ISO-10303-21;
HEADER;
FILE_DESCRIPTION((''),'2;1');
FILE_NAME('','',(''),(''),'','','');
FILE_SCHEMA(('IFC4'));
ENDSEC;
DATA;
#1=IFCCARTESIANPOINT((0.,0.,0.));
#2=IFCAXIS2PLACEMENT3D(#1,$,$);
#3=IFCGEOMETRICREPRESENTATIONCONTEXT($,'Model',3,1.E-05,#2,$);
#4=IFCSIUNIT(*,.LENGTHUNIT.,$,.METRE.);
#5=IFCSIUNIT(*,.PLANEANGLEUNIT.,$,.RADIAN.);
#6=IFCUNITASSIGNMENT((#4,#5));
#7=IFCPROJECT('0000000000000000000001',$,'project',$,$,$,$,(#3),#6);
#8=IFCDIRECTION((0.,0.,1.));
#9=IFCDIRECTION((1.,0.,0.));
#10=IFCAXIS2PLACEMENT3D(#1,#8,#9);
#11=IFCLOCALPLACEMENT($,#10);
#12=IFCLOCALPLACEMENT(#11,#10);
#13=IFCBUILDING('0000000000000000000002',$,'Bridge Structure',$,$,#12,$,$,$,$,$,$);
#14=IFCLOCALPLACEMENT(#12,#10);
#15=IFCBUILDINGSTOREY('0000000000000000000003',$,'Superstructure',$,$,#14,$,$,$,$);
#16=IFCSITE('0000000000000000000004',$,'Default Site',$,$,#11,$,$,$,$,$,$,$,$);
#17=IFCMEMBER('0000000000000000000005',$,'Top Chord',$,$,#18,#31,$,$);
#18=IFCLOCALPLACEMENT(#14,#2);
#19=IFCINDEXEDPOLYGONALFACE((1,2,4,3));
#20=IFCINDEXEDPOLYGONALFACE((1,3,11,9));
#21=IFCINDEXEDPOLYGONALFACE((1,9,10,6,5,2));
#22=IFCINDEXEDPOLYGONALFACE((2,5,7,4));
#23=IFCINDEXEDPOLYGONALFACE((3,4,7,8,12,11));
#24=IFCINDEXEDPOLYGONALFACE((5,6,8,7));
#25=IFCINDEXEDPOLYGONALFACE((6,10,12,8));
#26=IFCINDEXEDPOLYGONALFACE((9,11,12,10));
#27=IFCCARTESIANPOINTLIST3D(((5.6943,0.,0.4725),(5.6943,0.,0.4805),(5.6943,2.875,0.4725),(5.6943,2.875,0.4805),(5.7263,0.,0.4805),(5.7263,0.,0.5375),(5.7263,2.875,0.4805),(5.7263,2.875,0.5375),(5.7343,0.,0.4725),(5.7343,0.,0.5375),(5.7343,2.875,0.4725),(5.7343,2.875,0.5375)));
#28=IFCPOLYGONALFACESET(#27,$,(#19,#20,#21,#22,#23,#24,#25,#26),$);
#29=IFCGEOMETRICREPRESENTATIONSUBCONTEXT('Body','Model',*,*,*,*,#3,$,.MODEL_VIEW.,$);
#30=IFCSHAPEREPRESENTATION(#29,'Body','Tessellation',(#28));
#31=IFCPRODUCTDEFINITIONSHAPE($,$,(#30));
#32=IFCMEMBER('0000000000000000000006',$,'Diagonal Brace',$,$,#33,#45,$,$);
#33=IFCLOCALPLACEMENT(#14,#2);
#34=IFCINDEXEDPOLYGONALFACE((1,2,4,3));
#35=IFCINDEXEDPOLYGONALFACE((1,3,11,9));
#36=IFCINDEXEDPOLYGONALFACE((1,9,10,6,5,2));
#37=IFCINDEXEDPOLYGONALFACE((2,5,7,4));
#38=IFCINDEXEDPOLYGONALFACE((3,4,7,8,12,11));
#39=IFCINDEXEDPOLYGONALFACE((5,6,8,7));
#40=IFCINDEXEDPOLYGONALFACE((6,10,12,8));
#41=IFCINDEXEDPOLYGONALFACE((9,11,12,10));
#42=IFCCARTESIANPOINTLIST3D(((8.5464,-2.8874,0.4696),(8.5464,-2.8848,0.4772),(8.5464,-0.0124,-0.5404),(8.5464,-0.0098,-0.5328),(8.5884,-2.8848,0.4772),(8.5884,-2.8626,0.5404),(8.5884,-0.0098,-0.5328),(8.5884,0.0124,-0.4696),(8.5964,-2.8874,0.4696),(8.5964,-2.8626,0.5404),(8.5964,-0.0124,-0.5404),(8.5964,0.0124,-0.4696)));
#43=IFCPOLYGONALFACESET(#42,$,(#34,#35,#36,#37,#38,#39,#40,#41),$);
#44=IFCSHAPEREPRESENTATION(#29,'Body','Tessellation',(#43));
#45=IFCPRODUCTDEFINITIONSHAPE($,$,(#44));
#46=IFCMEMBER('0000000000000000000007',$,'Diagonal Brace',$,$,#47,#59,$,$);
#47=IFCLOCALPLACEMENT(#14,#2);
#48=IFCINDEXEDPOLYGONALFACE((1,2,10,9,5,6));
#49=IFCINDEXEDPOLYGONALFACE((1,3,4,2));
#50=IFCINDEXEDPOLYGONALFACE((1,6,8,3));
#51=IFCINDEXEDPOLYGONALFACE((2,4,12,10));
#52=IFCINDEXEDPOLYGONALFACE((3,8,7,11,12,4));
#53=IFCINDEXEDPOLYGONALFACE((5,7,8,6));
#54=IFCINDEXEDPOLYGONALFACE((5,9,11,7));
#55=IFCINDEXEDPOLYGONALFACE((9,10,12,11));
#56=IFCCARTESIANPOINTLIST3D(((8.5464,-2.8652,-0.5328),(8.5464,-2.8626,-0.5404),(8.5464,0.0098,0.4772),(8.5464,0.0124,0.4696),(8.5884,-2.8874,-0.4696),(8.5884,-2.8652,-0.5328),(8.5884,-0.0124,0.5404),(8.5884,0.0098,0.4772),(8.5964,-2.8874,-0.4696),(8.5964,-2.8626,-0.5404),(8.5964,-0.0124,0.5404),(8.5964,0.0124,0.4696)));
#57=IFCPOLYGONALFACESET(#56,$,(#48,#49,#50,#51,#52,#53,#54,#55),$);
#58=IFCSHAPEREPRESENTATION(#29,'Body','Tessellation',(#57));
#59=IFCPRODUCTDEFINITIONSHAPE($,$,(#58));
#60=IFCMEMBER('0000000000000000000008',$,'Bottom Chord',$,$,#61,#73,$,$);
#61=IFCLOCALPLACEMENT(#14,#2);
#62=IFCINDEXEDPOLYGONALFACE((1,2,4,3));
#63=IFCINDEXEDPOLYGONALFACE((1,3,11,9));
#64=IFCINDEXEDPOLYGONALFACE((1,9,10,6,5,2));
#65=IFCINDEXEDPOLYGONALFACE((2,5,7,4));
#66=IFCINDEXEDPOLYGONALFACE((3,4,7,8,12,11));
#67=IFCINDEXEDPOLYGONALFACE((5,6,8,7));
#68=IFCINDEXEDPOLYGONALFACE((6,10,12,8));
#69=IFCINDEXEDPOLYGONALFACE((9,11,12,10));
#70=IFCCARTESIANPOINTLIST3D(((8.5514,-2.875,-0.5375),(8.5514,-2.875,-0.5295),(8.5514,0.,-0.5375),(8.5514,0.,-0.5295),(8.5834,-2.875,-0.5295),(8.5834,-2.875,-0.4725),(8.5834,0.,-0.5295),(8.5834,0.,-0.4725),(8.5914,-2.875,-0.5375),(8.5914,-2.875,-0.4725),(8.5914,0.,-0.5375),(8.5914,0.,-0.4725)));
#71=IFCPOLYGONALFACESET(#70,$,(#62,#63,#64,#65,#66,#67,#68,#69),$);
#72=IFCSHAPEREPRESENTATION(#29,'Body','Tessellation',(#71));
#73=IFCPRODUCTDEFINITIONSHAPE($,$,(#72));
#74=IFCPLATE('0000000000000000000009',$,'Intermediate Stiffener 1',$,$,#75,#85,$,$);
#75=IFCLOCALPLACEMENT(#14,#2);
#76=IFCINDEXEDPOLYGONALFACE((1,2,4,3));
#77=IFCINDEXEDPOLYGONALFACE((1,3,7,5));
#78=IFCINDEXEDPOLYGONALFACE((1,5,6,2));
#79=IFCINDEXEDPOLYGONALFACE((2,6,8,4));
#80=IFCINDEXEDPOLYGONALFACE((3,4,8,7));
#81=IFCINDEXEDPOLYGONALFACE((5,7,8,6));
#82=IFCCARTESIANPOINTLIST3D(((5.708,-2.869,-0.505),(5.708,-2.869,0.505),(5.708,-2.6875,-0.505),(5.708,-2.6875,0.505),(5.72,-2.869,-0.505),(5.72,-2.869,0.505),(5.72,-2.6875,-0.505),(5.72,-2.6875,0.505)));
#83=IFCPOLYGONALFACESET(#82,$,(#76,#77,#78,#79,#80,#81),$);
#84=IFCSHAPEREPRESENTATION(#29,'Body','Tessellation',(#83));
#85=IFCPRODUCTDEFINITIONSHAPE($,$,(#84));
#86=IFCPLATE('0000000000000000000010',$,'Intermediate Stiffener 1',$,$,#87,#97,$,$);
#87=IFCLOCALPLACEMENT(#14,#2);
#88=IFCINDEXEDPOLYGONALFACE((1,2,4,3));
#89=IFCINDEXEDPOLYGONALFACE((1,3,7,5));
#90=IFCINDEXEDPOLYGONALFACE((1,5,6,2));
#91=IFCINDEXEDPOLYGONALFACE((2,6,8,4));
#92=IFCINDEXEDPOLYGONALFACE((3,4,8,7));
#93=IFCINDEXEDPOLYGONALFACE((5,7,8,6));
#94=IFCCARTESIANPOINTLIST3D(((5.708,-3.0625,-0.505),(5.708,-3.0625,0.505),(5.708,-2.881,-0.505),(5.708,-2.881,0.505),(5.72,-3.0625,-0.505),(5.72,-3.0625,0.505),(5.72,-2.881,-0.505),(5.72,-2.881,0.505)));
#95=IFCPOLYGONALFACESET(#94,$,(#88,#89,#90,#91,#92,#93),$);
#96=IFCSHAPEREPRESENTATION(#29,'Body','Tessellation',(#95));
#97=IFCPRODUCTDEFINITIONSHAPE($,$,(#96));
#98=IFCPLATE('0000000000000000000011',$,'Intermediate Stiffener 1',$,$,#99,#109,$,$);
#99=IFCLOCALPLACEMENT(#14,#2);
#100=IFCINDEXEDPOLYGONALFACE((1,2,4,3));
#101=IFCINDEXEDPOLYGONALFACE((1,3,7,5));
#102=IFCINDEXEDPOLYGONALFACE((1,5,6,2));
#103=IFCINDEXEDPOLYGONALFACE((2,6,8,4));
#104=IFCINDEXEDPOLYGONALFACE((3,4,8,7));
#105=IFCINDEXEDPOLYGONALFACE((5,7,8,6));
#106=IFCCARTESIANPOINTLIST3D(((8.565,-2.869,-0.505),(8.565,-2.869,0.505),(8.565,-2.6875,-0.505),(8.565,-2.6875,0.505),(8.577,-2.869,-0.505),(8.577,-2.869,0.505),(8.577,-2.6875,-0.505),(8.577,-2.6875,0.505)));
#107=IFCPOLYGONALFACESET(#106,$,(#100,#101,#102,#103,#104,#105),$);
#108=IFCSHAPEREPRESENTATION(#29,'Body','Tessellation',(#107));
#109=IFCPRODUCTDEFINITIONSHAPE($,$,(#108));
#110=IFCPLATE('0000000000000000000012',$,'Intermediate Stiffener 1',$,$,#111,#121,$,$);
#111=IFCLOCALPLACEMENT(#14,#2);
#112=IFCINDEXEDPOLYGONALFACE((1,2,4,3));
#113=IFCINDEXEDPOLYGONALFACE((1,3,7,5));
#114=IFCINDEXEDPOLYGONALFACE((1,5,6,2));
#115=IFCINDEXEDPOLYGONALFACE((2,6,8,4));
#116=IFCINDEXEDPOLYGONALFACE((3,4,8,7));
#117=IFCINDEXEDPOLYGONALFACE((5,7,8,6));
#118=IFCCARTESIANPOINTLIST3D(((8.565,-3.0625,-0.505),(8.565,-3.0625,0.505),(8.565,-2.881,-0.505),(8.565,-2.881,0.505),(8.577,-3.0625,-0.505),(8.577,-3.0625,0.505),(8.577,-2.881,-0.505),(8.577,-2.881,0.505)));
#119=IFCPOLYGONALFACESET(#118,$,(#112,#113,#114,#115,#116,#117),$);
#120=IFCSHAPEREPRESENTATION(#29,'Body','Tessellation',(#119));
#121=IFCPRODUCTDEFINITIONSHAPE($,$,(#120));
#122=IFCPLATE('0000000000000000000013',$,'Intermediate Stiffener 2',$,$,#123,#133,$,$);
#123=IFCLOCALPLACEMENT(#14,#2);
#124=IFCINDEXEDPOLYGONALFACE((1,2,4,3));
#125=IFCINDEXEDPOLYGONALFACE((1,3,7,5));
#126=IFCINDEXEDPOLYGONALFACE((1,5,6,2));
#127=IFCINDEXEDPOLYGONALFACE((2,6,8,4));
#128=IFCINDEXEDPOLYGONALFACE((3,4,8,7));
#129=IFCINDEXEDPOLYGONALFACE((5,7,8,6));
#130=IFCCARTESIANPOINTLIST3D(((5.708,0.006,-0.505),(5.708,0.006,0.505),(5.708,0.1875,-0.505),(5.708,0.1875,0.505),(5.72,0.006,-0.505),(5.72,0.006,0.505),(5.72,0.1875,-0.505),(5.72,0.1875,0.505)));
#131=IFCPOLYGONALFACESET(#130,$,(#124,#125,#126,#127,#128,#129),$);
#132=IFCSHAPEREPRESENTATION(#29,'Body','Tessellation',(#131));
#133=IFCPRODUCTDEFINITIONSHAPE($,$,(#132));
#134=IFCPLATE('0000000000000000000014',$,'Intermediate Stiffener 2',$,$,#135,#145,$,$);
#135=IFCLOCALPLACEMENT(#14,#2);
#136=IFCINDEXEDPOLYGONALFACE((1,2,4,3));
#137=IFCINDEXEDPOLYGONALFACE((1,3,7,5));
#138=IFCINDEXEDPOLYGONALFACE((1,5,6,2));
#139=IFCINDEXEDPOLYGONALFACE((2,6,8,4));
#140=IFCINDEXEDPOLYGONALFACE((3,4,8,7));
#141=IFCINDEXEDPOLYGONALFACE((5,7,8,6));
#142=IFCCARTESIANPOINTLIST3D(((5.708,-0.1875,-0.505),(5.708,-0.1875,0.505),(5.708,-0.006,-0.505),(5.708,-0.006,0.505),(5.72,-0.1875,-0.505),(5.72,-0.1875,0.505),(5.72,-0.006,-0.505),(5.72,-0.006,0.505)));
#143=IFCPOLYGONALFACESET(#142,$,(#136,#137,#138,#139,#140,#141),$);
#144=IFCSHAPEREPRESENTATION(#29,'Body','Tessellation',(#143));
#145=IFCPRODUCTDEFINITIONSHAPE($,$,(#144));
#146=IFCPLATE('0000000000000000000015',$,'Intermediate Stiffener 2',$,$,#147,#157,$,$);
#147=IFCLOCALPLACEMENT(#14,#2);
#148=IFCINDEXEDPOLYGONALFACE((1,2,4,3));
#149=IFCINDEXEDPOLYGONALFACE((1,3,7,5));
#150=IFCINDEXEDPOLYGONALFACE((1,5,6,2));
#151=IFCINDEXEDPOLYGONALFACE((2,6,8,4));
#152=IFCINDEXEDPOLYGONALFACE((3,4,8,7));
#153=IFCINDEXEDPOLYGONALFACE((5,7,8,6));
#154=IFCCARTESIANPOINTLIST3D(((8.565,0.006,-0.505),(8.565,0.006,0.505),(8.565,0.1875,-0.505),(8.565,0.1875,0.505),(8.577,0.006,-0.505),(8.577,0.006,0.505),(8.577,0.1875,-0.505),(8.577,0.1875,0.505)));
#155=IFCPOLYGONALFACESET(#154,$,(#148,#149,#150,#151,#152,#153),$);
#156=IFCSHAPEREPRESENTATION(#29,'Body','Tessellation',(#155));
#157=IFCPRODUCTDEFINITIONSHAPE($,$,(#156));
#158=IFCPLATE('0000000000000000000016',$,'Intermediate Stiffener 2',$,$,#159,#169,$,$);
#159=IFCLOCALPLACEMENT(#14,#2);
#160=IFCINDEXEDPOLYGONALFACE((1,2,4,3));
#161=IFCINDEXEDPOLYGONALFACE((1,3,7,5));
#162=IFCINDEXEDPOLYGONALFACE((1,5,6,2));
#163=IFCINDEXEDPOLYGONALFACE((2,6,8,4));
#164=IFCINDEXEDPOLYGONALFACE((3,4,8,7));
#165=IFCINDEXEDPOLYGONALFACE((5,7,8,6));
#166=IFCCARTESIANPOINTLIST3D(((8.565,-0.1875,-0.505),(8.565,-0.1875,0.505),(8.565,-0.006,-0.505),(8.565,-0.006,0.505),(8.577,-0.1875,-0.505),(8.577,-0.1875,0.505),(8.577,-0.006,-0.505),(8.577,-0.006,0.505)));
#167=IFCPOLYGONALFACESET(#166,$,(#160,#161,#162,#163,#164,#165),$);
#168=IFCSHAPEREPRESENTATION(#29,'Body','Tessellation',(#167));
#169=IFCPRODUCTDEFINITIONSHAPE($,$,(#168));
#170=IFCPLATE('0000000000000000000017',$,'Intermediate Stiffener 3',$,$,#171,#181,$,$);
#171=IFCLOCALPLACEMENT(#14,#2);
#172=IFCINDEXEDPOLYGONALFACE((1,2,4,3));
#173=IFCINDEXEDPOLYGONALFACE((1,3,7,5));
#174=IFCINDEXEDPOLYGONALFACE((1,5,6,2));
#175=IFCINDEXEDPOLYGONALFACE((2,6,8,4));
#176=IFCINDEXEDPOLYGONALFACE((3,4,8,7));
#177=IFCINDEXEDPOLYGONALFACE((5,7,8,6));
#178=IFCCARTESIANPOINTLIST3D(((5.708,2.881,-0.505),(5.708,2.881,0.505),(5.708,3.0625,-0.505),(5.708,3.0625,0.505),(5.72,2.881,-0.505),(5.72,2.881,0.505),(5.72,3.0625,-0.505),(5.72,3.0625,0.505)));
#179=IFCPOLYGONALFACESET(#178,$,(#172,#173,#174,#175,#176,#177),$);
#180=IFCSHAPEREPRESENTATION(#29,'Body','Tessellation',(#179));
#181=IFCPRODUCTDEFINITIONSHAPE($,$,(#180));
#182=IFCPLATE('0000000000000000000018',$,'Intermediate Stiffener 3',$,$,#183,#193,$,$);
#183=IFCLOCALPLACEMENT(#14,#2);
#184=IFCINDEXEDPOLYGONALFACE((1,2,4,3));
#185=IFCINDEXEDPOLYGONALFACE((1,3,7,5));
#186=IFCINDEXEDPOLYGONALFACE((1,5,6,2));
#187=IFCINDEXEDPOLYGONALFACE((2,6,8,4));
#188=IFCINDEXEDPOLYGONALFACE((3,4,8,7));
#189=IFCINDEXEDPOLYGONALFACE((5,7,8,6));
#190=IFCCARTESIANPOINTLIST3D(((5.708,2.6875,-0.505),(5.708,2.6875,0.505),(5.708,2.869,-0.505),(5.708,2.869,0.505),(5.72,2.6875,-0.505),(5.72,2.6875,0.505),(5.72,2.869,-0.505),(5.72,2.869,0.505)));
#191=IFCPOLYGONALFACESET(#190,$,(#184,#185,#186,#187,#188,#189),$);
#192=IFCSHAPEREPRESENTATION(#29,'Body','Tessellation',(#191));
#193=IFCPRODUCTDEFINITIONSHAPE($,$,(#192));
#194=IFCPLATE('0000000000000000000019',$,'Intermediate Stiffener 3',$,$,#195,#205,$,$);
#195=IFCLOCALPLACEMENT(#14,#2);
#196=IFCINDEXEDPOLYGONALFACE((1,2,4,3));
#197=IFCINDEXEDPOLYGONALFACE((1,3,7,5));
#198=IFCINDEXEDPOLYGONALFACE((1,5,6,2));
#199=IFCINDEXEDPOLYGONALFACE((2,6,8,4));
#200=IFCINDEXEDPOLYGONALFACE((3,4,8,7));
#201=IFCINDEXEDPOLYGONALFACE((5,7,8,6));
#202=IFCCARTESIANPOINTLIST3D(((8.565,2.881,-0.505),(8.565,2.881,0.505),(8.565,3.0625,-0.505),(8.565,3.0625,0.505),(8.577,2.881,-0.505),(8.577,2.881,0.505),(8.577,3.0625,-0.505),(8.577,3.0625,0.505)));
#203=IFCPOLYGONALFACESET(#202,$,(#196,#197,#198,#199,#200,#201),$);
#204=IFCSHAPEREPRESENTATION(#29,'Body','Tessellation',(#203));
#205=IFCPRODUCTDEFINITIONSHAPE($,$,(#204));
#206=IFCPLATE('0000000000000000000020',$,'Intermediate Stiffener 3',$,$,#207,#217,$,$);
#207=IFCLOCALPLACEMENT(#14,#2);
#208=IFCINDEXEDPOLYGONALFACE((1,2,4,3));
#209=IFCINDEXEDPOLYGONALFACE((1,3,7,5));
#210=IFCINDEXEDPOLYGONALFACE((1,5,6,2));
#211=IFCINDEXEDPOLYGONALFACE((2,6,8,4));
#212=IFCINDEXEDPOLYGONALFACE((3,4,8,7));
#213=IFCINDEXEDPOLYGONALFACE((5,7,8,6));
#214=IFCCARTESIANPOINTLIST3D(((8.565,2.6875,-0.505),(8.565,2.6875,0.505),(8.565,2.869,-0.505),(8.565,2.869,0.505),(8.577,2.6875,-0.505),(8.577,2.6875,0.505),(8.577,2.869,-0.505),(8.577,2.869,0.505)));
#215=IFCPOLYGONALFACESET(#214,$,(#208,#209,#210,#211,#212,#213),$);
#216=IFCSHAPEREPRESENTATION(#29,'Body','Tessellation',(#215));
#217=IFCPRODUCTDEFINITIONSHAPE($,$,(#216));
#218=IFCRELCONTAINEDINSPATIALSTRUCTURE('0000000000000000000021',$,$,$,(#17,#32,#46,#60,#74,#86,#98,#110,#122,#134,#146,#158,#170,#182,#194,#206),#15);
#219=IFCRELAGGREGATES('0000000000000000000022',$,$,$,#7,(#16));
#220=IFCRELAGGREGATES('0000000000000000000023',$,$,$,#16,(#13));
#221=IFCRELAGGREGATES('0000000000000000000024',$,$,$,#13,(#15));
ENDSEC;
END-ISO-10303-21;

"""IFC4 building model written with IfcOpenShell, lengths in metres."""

from ifc_helpers import new_model, si_unit, frame, origin, origin_with_axes, origin_2d_with_axis, place, context, subcontext, project, spatial, rectangle, l_section, extrude, element, save


model = new_model("IFC4")

# Units and contexts
model_context = context("Model", 3, precision=1e-05, world=origin())
body_context = subcontext(model_context, "Body", "Model", "MODEL_VIEW")
ifc_project = project(units=[si_unit("LENGTHUNIT", "METRE"), si_unit("PLANEANGLEUNIT", "RADIAN")], contexts=[model_context])

# Site, building, storey
site_placement = place(None, origin_with_axes())
site = spatial("IfcSite", under=ifc_project, at=site_placement, Name="Default Site")
building_placement = place(site_placement, origin_with_axes())
building = spatial("IfcBuilding", under=site, at=building_placement, Name="Bridge Structure")
storey_placement = place(building_placement, origin_with_axes())
storey = spatial("IfcBuildingStorey", under=building, at=storey_placement, Name="Superstructure")

# Members
for number, where, z_axis, x_axis, name in (
    (1, (5.7143, 0.0, 0.505), (0.0, 1.0, 0.0), (-1.0, 0.0, 0.0), "Top Chord"),
):
    element("IfcMember", number, at=place(storey_placement, frame(where, z_axis=z_axis, x_axis=x_axis)), inside=storey, Name=name, context=body_context, shape_type="SweptSolid", body=[
        extrude(l_section(Depth=0.065, Width=0.04, Thickness=0.008, at=origin_2d_with_axis()), origin_with_axes(), (0.0, 0.0, 1.0), 2.875),
    ])
for number, where, z_axis, x_axis, name in (
    (2, (8.5714, -2.875, 0.505), (0.0, 0.943474, -0.331447), (-1.0, 0.0, 0.0), "Diagonal Brace"),
    (3, (8.5714, -2.875, -0.505), (0.0, 0.943474, 0.331447), (-1.0, 0.0, 0.0), "Diagonal Brace"),
):
    element("IfcMember", number, at=place(storey_placement, frame(where, z_axis=z_axis, x_axis=x_axis)), inside=storey, Name=name, context=body_context, shape_type="SweptSolid", body=[
        extrude(l_section(Depth=0.075, Width=0.05, Thickness=0.008, at=origin_2d_with_axis()), origin_with_axes(), (0.0, 0.0, 1.0), 3.0472),
    ])
member_placement = place(storey_placement, frame((8.5714, -2.875, -0.505), z_axis=(0.0, 1.0, 0.0), x_axis=(-1.0, 0.0, 0.0)))
element("IfcMember", 4, at=member_placement, inside=storey, Name="Bottom Chord", context=body_context, shape_type="SweptSolid", body=[
    extrude(l_section(Depth=0.065, Width=0.04, Thickness=0.008, at=origin_2d_with_axis()), origin_with_axes(), (0.0, 0.0, 1.0), 2.875),
])

# Plates
for number, where, z_axis, x_axis, name in (
    (5, (5.714, -2.7782, -0.505), (0.0, 0.0, 1.0), (1.0, 0.0, 0.0), "Intermediate Stiffener 1"),
    (6, (5.714, -2.9718, -0.505), (0.0, 0.0, 1.0), (1.0, 0.0, 0.0), "Intermediate Stiffener 1"),
    (7, (8.571, -2.7782, -0.505), (0.0, 0.0, 1.0), (1.0, 0.0, 0.0), "Intermediate Stiffener 1"),
    (8, (8.571, -2.9718, -0.505), (0.0, 0.0, 1.0), (1.0, 0.0, 0.0), "Intermediate Stiffener 1"),
    (9, (5.714, 0.0968, -0.505), (0.0, 0.0, 1.0), (1.0, 0.0, 0.0), "Intermediate Stiffener 2"),
    (10, (5.714, -0.0968, -0.505), (0.0, 0.0, 1.0), (1.0, 0.0, 0.0), "Intermediate Stiffener 2"),
    (11, (8.571, 0.0968, -0.505), (0.0, 0.0, 1.0), (1.0, 0.0, 0.0), "Intermediate Stiffener 2"),
    (12, (8.571, -0.0968, -0.505), (0.0, 0.0, 1.0), (1.0, 0.0, 0.0), "Intermediate Stiffener 2"),
    (13, (5.714, 2.9718, -0.505), (0.0, 0.0, 1.0), (1.0, 0.0, 0.0), "Intermediate Stiffener 3"),
    (14, (5.714, 2.7782, -0.505), (0.0, 0.0, 1.0), (1.0, 0.0, 0.0), "Intermediate Stiffener 3"),
    (15, (8.571, 2.9718, -0.505), (0.0, 0.0, 1.0), (1.0, 0.0, 0.0), "Intermediate Stiffener 3"),
    (16, (8.571, 2.7782, -0.505), (0.0, 0.0, 1.0), (1.0, 0.0, 0.0), "Intermediate Stiffener 3"),
):
    element("IfcPlate", number, at=place(storey_placement, frame(where, z_axis=z_axis, x_axis=x_axis)), inside=storey, Name=name, context=body_context, shape_type="SweptSolid", body=[
        extrude(rectangle(XDim=0.012, YDim=0.1815, at=origin_2d_with_axis()), origin_with_axes(), (0.0, 0.0, 1.0), 1.01),
    ])

save(model, "model.ifc")
